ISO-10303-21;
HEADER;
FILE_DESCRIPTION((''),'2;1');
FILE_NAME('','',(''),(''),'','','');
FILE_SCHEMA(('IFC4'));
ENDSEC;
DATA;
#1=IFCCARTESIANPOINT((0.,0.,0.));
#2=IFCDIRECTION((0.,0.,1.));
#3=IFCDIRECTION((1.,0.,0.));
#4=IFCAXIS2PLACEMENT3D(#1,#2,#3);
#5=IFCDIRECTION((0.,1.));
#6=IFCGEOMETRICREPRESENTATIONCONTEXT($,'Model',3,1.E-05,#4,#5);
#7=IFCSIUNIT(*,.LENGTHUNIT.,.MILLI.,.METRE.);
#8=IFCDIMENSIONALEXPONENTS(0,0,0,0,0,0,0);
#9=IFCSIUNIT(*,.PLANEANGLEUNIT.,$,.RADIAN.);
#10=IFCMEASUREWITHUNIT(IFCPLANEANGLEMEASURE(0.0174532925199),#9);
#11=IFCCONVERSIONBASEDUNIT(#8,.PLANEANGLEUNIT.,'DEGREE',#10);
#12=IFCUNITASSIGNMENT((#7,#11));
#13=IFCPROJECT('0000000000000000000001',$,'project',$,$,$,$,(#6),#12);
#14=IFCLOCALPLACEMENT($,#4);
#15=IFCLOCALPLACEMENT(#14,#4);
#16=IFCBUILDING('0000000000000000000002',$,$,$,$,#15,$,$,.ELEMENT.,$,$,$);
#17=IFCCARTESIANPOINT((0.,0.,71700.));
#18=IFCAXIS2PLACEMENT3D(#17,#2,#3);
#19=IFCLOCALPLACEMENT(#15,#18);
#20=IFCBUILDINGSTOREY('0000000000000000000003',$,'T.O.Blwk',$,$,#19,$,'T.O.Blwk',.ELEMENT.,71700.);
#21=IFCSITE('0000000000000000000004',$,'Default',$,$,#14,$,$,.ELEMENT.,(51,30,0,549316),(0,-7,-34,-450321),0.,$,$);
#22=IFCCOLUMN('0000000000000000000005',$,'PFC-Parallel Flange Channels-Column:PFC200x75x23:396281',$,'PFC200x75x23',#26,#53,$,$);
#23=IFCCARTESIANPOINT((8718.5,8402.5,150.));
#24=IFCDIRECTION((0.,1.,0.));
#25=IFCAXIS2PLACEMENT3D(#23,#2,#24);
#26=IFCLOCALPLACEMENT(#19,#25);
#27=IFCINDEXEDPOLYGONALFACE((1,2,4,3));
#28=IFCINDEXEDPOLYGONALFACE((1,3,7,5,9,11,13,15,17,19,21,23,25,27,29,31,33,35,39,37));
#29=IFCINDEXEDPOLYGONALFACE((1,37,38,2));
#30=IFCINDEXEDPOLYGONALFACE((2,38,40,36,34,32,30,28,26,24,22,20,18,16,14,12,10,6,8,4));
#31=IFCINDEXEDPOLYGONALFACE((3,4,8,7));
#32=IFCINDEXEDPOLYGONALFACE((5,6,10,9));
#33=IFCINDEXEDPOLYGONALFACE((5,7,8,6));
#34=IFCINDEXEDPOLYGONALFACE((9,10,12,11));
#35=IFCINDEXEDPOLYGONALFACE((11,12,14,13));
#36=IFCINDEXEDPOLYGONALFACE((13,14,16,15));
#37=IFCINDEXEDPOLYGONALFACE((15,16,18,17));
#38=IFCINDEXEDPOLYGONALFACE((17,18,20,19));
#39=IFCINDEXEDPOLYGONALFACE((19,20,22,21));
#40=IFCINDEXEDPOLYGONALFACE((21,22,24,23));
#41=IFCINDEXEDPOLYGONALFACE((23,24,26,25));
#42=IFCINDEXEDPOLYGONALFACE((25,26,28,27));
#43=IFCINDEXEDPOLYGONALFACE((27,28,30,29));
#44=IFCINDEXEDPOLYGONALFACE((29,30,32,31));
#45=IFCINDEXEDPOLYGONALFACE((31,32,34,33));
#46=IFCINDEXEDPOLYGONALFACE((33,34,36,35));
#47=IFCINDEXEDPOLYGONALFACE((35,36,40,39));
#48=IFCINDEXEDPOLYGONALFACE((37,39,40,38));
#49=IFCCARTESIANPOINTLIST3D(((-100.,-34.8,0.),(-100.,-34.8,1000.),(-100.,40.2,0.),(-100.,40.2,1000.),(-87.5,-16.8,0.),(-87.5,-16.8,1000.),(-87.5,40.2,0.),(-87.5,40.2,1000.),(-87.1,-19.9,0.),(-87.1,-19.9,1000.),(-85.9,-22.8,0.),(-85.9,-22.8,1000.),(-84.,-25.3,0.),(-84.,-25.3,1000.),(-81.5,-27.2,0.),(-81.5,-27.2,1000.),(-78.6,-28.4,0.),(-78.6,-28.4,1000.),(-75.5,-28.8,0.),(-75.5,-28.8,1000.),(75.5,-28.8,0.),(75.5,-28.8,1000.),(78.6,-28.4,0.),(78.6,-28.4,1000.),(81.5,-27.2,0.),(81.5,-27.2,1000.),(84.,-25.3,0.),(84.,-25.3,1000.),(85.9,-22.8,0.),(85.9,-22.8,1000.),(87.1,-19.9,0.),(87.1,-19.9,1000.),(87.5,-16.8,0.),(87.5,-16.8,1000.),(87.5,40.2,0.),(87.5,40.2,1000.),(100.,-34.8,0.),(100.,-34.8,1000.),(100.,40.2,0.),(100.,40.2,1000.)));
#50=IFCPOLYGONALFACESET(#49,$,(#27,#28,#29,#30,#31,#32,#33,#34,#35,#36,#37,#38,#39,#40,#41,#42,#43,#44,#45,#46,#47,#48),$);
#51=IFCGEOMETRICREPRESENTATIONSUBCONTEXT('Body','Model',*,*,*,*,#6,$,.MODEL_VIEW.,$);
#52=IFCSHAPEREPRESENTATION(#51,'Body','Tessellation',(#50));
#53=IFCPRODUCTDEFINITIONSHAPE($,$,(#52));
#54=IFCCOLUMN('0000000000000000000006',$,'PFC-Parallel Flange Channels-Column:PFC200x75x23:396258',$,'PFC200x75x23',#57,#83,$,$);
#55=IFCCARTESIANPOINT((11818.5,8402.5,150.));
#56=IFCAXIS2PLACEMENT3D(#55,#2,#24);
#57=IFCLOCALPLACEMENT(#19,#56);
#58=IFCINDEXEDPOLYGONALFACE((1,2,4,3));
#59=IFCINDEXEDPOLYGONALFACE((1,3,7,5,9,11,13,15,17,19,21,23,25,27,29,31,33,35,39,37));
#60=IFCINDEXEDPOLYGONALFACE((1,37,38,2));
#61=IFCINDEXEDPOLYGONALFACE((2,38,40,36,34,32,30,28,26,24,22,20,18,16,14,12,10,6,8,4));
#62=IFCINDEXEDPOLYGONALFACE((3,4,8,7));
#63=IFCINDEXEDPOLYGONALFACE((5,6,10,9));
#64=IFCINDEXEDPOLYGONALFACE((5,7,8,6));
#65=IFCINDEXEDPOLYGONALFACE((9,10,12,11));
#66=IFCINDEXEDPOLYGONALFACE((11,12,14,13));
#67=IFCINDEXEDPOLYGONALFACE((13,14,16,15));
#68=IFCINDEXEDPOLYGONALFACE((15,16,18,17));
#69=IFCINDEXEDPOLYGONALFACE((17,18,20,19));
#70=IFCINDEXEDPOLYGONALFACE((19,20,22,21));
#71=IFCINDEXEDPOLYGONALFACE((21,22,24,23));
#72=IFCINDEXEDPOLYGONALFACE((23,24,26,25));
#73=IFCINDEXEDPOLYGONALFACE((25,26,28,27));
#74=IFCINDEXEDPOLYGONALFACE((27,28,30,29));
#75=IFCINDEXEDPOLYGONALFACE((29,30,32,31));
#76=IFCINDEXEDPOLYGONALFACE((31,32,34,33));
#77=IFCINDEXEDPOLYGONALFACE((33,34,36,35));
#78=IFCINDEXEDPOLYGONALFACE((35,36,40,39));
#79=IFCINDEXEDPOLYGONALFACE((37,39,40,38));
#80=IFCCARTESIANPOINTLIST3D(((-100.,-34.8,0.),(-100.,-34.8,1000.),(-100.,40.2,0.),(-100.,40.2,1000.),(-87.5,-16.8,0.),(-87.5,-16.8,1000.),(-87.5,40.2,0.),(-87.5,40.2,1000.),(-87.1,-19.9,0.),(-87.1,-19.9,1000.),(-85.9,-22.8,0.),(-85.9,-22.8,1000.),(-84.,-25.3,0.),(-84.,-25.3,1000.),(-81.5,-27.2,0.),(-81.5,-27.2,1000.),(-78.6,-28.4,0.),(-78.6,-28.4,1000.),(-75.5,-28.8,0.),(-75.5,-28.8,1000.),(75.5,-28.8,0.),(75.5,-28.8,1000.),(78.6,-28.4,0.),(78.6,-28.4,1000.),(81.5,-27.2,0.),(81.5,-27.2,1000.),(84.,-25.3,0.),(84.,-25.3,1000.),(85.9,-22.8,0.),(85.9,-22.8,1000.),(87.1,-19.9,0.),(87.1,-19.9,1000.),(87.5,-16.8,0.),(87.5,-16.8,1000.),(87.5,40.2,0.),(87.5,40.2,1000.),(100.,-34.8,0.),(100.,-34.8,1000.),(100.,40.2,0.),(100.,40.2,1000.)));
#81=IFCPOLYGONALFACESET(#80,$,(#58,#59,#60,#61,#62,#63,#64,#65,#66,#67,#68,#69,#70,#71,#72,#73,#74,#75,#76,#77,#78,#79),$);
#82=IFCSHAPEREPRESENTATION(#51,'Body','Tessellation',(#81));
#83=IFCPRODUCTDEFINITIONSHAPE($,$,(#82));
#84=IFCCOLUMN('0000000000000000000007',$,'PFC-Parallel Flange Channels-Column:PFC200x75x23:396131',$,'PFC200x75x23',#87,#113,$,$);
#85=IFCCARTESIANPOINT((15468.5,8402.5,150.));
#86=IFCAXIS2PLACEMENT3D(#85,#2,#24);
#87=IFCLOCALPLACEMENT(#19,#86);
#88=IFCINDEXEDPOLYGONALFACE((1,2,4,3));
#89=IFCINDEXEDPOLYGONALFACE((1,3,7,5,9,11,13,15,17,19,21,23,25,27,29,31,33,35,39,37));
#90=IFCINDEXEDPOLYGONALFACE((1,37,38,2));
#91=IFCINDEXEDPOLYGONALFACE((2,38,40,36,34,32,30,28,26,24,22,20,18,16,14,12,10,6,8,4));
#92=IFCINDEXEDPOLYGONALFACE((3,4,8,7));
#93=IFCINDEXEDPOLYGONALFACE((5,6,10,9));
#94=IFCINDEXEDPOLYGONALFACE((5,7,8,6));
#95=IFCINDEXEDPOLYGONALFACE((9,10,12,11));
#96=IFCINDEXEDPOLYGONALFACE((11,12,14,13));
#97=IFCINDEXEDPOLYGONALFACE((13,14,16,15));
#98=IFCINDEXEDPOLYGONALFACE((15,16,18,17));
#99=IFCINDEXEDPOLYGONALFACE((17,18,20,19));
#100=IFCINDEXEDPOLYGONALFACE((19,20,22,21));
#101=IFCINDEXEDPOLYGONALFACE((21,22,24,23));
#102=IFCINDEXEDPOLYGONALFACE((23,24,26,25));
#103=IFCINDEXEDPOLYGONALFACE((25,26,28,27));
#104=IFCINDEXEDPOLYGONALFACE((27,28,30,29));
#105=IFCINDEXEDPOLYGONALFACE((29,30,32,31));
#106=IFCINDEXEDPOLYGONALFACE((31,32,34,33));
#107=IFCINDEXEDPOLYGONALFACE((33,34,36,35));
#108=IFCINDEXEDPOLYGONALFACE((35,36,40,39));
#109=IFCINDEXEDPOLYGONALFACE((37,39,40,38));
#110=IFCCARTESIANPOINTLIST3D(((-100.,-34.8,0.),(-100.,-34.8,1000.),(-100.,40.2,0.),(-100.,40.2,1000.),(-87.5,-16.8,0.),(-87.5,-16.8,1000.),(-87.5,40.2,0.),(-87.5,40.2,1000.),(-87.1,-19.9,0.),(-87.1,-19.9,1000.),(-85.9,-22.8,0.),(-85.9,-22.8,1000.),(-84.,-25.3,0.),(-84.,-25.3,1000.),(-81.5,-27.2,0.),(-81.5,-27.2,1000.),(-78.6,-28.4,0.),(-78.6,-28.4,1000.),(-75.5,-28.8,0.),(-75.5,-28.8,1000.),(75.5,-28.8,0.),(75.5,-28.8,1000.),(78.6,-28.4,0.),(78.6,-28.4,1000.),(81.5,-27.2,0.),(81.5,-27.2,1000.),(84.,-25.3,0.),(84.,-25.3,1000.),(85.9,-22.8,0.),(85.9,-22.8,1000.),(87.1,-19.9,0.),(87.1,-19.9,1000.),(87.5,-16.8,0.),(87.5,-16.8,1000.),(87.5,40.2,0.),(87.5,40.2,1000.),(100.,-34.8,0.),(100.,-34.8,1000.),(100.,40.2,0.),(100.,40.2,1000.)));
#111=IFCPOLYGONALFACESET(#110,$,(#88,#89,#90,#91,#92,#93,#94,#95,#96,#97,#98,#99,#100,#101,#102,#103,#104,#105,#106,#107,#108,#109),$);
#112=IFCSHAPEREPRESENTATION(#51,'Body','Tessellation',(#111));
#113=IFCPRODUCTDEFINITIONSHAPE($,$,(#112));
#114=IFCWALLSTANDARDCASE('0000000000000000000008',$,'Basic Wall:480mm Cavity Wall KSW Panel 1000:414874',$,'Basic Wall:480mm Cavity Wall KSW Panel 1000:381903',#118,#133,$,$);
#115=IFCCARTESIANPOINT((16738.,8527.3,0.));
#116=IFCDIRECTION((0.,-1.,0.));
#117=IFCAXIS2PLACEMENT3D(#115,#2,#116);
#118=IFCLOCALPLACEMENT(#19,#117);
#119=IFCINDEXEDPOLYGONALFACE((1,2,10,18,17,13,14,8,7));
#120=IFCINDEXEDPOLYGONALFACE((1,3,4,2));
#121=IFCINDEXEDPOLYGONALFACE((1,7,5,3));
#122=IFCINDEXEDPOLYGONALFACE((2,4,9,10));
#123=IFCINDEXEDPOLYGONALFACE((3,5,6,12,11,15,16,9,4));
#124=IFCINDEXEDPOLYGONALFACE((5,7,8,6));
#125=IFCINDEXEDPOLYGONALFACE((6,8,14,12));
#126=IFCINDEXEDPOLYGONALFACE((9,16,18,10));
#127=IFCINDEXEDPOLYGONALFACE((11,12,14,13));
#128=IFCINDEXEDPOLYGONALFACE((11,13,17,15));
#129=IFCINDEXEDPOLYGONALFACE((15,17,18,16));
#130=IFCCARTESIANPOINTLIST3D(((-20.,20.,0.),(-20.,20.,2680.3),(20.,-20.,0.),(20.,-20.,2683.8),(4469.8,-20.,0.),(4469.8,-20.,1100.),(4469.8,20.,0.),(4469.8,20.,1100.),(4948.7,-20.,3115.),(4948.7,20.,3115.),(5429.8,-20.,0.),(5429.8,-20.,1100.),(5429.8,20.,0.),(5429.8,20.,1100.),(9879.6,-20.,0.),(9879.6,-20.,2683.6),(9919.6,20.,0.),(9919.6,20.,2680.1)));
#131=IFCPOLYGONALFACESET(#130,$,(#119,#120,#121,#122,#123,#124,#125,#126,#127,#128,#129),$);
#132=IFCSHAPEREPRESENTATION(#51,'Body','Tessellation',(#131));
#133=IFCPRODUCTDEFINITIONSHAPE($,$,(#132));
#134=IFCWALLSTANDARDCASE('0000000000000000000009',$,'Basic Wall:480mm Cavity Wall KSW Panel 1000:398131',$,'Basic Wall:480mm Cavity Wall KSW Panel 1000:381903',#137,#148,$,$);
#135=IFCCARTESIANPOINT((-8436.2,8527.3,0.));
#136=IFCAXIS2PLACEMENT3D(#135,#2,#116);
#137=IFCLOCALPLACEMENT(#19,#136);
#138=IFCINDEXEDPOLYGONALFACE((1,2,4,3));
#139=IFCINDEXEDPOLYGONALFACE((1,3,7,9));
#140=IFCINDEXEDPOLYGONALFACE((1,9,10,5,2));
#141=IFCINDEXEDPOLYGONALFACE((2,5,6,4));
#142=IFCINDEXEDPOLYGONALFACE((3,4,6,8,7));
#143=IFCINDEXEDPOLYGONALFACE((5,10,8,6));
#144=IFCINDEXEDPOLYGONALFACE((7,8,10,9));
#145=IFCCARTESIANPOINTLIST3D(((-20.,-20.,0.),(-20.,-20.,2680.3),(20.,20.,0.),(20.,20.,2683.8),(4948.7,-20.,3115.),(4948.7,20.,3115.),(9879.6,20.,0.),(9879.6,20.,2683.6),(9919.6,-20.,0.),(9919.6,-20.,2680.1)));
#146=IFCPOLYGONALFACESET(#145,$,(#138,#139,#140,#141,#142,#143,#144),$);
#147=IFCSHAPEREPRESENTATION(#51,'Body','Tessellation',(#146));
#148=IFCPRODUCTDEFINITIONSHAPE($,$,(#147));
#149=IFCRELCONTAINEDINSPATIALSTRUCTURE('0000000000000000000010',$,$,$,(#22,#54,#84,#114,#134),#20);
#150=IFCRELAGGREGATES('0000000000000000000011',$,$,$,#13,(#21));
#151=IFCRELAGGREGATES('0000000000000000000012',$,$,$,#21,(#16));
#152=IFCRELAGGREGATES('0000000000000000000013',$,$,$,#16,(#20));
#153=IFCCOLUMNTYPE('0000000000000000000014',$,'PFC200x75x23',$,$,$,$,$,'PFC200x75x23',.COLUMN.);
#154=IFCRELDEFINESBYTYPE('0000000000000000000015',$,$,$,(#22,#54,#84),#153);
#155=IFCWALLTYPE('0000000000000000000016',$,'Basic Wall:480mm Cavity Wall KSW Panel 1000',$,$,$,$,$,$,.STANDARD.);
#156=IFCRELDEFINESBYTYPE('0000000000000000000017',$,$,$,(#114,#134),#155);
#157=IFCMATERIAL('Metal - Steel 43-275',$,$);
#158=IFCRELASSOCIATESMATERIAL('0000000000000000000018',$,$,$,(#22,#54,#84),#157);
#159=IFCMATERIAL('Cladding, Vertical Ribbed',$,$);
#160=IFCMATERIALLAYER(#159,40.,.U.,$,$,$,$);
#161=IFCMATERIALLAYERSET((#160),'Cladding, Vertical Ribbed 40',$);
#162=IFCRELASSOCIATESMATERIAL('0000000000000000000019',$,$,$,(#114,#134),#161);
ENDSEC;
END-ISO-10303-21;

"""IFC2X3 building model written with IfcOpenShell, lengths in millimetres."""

from ifc_helpers import new_model, entity, si_unit, converted_unit, point, direction, frame, frame_2d, origin_with_axes, place, context, subcontext, project, spatial, polyline, circle_curve, parameter, trimmed, segment, composite_curve, outline, extrude, clip, halfspace, material, layer, layer_set, layer_usage, type_object, element, save


model = new_model("IFC2X3")

# Units and contexts
model_context = context("Model", 3, precision=1e-05, world=origin_with_axes(), true_north=direction((0.0, 1.0)))
body_context = subcontext(model_context, "Body", "Model", "MODEL_VIEW")
ifc_project = project(units=[si_unit("LENGTHUNIT", "METRE", prefix="MILLI"), converted_unit("PLANEANGLEUNIT", "DEGREE", entity("IfcPlaneAngleMeasure", 0.0174532925199), si_unit("PLANEANGLEUNIT", "RADIAN"), dimensions=[0, 0, 0, 0, 0, 0, 0])], contexts=[model_context])

# Site, building, storey
site_placement = place(None, origin_with_axes())
site = spatial("IfcSite", under=ifc_project, at=site_placement, Name="Default", CompositionType="ELEMENT", RefLatitude=(51, 30, 0, 549316), RefLongitude=(0, -7, -34, -450321), RefElevation=0.0)
building_placement = place(site_placement, origin_with_axes())
building = spatial("IfcBuilding", under=site, at=building_placement, CompositionType="ELEMENT")
storey_placement = place(building_placement, frame((0.0, 0.0, 71700.0), z_axis=(0.0, 0.0, 1.0), x_axis=(1.0, 0.0, 0.0)))
storey = spatial("IfcBuildingStorey", under=building, at=storey_placement, Name="T.O.Blwk", LongName="T.O.Blwk", CompositionType="ELEMENT", Elevation=71700.0)

# Columns
ifc_material_1 = material(Name="Metal - Steel 43-275")
column_type_1 = type_object("IfcColumnType", Name="PFC200x75x23", ElementType="PFC200x75x23", PredefinedType="COLUMN")
for number, where, z_axis, x_axis, name in (
    (1, (8718.5, 8402.5, 150.0), (0.0, 0.0, 1.0), (0.0, 1.0, 0.0), "PFC-Parallel Flange Channels-Column:PFC200x75x23:396281"),
    (2, (11818.5, 8402.5, 150.0), (0.0, 0.0, 1.0), (0.0, 1.0, 0.0), "PFC-Parallel Flange Channels-Column:PFC200x75x23:396258"),
    (3, (15468.5, 8402.5, 150.0), (0.0, 0.0, 1.0), (0.0, 1.0, 0.0), "PFC-Parallel Flange Channels-Column:PFC200x75x23:396131"),
):
    element("IfcColumn", number, at=place(storey_placement, frame(where, z_axis=z_axis, x_axis=x_axis)), inside=storey, type_object=column_type_1, material=ifc_material_1, Name=name, ObjectType="PFC200x75x23", context=body_context, shape_type="SweptSolid", body=[
        extrude(outline(composite_curve([segment(polyline([(-100.0, -34.8), (100.0, -34.8), (100.0, 40.2), (87.5, 40.2), (87.5, -16.8)]), True, "CONTINUOUS"), segment(trimmed(circle_curve(frame_2d((75.5, -16.8), x_axis=(0.0, -1.0)), 12.0), [point((87.5, -16.8)), parameter(90.0)], [point((75.5, -28.8)), parameter(0.0)], False, "CARTESIAN"), True, "CONTINUOUS"), segment(polyline([(75.5, -28.8), (-75.5, -28.8)]), True, "CONTINUOUS"), segment(trimmed(circle_curve(frame_2d((-75.5, -16.8), x_axis=(-1.0, 0.0)), 12.0), [point((-75.5, -28.8)), parameter(90.0)], [point((-87.5, -16.8)), parameter(0.0)], False, "CARTESIAN"), True, "CONTINUOUS"), segment(polyline([(-87.5, -16.8), (-87.5, 40.2), (-100.0, 40.2), (-100.0, -34.8)]), True, "CONTINUOUS")], self_intersect=False)), origin_with_axes(), (0.0, 0.0, 1.0), 1000.0),
    ])

# Wall, opening
ifc_material_2 = material(Name="Cladding, Vertical Ribbed")
ifc_layer_1 = layer(ifc_material_2, 40.0, ventilated="UNKNOWN")
ifc_layer_set_1 = layer_set([ifc_layer_1], Name="Cladding, Vertical Ribbed 40")
ifc_layer_usage_1 = layer_usage(ifc_layer_set_1, "AXIS2", "POSITIVE", -20.0)
wall_type_1 = type_object("IfcWallType", Name="Basic Wall:480mm Cavity Wall KSW Panel 1000", PredefinedType="STANDARD")
wall_1_placement = place(storey_placement, frame((16738.0, 8527.3, 0.0), z_axis=(0.0, 0.0, 1.0), x_axis=(0.0, -1.0, 0.0)))
wall_1 = element("IfcWallStandardCase", 4, at=wall_1_placement, inside=storey, type_object=wall_type_1, material=ifc_layer_usage_1, Name="Basic Wall:480mm Cavity Wall KSW Panel 1000:414874", ObjectType="Basic Wall:480mm Cavity Wall KSW Panel 1000:381903", context=body_context, shape_type="Clipping", body=[
    clip(clip(extrude(outline(polyline([(20.0, -20.0), (9879.6, -20.0), (9919.6, 20.0), (-20.0, 20.0), (20.0, -20.0)])), origin_with_axes(), (0.0, 0.0, 1.0), 3115.0), halfspace(frame((-232.9, 0.0, 2661.7), z_axis=(0.087156, 0.0, -0.996195), x_axis=(0.0, 1.0, 0.0)), True)), halfspace(frame((308.1, 0.0, 3521.0), z_axis=(-0.087156, 0.0, -0.996195), x_axis=(0.0, 1.0, 0.0)), True)),
])
opening_1_placement = place(wall_1_placement, frame((4949.8, 0.0, -1000.0), z_axis=(0.0, 0.0, 1.0), x_axis=(1.0, 0.0, 0.0)))
element("IfcOpeningElement", 5, at=opening_1_placement, cuts=wall_1, context=body_context, shape_type="SweptSolid", body=[
    extrude(outline(polyline([(480.0, 0.0), (-480.0, 0.0), (-480.0, -2100.0), (480.0, -2100.0), (480.0, 0.0)])), frame((0.0, -20.0, 0.0), z_axis=(0.0, 1.0, 0.0), x_axis=(1.0, 0.0, 0.0)), (0.0, 0.0, 1.0), 40.0),
])

# Wall
ifc_layer_usage_2 = layer_usage(ifc_layer_set_1, "AXIS2", "POSITIVE", -20.0)
wall_2_placement = place(storey_placement, frame((-8436.2, 8527.3, 0.0), z_axis=(0.0, 0.0, 1.0), x_axis=(0.0, -1.0, 0.0)))
element("IfcWallStandardCase", 6, at=wall_2_placement, inside=storey, type_object=wall_type_1, material=ifc_layer_usage_2, Name="Basic Wall:480mm Cavity Wall KSW Panel 1000:398131", ObjectType="Basic Wall:480mm Cavity Wall KSW Panel 1000:381903", context=body_context, shape_type="Clipping", body=[
    clip(clip(extrude(outline(polyline([(-20.0, -20.0), (9919.6, -20.0), (9879.6, 20.0), (20.0, 20.0), (-20.0, -20.0)])), origin_with_axes(), (0.0, 0.0, 1.0), 3115.0), halfspace(frame((-232.9, 0.0, 2661.7), z_axis=(0.087156, 0.0, -0.996195), x_axis=(0.0, 1.0, 0.0)), True)), halfspace(frame((308.1, 0.0, 3521.0), z_axis=(-0.087156, 0.0, -0.996195), x_axis=(0.0, 1.0, 0.0)), True)),
])

save(model, "model.ifc")
